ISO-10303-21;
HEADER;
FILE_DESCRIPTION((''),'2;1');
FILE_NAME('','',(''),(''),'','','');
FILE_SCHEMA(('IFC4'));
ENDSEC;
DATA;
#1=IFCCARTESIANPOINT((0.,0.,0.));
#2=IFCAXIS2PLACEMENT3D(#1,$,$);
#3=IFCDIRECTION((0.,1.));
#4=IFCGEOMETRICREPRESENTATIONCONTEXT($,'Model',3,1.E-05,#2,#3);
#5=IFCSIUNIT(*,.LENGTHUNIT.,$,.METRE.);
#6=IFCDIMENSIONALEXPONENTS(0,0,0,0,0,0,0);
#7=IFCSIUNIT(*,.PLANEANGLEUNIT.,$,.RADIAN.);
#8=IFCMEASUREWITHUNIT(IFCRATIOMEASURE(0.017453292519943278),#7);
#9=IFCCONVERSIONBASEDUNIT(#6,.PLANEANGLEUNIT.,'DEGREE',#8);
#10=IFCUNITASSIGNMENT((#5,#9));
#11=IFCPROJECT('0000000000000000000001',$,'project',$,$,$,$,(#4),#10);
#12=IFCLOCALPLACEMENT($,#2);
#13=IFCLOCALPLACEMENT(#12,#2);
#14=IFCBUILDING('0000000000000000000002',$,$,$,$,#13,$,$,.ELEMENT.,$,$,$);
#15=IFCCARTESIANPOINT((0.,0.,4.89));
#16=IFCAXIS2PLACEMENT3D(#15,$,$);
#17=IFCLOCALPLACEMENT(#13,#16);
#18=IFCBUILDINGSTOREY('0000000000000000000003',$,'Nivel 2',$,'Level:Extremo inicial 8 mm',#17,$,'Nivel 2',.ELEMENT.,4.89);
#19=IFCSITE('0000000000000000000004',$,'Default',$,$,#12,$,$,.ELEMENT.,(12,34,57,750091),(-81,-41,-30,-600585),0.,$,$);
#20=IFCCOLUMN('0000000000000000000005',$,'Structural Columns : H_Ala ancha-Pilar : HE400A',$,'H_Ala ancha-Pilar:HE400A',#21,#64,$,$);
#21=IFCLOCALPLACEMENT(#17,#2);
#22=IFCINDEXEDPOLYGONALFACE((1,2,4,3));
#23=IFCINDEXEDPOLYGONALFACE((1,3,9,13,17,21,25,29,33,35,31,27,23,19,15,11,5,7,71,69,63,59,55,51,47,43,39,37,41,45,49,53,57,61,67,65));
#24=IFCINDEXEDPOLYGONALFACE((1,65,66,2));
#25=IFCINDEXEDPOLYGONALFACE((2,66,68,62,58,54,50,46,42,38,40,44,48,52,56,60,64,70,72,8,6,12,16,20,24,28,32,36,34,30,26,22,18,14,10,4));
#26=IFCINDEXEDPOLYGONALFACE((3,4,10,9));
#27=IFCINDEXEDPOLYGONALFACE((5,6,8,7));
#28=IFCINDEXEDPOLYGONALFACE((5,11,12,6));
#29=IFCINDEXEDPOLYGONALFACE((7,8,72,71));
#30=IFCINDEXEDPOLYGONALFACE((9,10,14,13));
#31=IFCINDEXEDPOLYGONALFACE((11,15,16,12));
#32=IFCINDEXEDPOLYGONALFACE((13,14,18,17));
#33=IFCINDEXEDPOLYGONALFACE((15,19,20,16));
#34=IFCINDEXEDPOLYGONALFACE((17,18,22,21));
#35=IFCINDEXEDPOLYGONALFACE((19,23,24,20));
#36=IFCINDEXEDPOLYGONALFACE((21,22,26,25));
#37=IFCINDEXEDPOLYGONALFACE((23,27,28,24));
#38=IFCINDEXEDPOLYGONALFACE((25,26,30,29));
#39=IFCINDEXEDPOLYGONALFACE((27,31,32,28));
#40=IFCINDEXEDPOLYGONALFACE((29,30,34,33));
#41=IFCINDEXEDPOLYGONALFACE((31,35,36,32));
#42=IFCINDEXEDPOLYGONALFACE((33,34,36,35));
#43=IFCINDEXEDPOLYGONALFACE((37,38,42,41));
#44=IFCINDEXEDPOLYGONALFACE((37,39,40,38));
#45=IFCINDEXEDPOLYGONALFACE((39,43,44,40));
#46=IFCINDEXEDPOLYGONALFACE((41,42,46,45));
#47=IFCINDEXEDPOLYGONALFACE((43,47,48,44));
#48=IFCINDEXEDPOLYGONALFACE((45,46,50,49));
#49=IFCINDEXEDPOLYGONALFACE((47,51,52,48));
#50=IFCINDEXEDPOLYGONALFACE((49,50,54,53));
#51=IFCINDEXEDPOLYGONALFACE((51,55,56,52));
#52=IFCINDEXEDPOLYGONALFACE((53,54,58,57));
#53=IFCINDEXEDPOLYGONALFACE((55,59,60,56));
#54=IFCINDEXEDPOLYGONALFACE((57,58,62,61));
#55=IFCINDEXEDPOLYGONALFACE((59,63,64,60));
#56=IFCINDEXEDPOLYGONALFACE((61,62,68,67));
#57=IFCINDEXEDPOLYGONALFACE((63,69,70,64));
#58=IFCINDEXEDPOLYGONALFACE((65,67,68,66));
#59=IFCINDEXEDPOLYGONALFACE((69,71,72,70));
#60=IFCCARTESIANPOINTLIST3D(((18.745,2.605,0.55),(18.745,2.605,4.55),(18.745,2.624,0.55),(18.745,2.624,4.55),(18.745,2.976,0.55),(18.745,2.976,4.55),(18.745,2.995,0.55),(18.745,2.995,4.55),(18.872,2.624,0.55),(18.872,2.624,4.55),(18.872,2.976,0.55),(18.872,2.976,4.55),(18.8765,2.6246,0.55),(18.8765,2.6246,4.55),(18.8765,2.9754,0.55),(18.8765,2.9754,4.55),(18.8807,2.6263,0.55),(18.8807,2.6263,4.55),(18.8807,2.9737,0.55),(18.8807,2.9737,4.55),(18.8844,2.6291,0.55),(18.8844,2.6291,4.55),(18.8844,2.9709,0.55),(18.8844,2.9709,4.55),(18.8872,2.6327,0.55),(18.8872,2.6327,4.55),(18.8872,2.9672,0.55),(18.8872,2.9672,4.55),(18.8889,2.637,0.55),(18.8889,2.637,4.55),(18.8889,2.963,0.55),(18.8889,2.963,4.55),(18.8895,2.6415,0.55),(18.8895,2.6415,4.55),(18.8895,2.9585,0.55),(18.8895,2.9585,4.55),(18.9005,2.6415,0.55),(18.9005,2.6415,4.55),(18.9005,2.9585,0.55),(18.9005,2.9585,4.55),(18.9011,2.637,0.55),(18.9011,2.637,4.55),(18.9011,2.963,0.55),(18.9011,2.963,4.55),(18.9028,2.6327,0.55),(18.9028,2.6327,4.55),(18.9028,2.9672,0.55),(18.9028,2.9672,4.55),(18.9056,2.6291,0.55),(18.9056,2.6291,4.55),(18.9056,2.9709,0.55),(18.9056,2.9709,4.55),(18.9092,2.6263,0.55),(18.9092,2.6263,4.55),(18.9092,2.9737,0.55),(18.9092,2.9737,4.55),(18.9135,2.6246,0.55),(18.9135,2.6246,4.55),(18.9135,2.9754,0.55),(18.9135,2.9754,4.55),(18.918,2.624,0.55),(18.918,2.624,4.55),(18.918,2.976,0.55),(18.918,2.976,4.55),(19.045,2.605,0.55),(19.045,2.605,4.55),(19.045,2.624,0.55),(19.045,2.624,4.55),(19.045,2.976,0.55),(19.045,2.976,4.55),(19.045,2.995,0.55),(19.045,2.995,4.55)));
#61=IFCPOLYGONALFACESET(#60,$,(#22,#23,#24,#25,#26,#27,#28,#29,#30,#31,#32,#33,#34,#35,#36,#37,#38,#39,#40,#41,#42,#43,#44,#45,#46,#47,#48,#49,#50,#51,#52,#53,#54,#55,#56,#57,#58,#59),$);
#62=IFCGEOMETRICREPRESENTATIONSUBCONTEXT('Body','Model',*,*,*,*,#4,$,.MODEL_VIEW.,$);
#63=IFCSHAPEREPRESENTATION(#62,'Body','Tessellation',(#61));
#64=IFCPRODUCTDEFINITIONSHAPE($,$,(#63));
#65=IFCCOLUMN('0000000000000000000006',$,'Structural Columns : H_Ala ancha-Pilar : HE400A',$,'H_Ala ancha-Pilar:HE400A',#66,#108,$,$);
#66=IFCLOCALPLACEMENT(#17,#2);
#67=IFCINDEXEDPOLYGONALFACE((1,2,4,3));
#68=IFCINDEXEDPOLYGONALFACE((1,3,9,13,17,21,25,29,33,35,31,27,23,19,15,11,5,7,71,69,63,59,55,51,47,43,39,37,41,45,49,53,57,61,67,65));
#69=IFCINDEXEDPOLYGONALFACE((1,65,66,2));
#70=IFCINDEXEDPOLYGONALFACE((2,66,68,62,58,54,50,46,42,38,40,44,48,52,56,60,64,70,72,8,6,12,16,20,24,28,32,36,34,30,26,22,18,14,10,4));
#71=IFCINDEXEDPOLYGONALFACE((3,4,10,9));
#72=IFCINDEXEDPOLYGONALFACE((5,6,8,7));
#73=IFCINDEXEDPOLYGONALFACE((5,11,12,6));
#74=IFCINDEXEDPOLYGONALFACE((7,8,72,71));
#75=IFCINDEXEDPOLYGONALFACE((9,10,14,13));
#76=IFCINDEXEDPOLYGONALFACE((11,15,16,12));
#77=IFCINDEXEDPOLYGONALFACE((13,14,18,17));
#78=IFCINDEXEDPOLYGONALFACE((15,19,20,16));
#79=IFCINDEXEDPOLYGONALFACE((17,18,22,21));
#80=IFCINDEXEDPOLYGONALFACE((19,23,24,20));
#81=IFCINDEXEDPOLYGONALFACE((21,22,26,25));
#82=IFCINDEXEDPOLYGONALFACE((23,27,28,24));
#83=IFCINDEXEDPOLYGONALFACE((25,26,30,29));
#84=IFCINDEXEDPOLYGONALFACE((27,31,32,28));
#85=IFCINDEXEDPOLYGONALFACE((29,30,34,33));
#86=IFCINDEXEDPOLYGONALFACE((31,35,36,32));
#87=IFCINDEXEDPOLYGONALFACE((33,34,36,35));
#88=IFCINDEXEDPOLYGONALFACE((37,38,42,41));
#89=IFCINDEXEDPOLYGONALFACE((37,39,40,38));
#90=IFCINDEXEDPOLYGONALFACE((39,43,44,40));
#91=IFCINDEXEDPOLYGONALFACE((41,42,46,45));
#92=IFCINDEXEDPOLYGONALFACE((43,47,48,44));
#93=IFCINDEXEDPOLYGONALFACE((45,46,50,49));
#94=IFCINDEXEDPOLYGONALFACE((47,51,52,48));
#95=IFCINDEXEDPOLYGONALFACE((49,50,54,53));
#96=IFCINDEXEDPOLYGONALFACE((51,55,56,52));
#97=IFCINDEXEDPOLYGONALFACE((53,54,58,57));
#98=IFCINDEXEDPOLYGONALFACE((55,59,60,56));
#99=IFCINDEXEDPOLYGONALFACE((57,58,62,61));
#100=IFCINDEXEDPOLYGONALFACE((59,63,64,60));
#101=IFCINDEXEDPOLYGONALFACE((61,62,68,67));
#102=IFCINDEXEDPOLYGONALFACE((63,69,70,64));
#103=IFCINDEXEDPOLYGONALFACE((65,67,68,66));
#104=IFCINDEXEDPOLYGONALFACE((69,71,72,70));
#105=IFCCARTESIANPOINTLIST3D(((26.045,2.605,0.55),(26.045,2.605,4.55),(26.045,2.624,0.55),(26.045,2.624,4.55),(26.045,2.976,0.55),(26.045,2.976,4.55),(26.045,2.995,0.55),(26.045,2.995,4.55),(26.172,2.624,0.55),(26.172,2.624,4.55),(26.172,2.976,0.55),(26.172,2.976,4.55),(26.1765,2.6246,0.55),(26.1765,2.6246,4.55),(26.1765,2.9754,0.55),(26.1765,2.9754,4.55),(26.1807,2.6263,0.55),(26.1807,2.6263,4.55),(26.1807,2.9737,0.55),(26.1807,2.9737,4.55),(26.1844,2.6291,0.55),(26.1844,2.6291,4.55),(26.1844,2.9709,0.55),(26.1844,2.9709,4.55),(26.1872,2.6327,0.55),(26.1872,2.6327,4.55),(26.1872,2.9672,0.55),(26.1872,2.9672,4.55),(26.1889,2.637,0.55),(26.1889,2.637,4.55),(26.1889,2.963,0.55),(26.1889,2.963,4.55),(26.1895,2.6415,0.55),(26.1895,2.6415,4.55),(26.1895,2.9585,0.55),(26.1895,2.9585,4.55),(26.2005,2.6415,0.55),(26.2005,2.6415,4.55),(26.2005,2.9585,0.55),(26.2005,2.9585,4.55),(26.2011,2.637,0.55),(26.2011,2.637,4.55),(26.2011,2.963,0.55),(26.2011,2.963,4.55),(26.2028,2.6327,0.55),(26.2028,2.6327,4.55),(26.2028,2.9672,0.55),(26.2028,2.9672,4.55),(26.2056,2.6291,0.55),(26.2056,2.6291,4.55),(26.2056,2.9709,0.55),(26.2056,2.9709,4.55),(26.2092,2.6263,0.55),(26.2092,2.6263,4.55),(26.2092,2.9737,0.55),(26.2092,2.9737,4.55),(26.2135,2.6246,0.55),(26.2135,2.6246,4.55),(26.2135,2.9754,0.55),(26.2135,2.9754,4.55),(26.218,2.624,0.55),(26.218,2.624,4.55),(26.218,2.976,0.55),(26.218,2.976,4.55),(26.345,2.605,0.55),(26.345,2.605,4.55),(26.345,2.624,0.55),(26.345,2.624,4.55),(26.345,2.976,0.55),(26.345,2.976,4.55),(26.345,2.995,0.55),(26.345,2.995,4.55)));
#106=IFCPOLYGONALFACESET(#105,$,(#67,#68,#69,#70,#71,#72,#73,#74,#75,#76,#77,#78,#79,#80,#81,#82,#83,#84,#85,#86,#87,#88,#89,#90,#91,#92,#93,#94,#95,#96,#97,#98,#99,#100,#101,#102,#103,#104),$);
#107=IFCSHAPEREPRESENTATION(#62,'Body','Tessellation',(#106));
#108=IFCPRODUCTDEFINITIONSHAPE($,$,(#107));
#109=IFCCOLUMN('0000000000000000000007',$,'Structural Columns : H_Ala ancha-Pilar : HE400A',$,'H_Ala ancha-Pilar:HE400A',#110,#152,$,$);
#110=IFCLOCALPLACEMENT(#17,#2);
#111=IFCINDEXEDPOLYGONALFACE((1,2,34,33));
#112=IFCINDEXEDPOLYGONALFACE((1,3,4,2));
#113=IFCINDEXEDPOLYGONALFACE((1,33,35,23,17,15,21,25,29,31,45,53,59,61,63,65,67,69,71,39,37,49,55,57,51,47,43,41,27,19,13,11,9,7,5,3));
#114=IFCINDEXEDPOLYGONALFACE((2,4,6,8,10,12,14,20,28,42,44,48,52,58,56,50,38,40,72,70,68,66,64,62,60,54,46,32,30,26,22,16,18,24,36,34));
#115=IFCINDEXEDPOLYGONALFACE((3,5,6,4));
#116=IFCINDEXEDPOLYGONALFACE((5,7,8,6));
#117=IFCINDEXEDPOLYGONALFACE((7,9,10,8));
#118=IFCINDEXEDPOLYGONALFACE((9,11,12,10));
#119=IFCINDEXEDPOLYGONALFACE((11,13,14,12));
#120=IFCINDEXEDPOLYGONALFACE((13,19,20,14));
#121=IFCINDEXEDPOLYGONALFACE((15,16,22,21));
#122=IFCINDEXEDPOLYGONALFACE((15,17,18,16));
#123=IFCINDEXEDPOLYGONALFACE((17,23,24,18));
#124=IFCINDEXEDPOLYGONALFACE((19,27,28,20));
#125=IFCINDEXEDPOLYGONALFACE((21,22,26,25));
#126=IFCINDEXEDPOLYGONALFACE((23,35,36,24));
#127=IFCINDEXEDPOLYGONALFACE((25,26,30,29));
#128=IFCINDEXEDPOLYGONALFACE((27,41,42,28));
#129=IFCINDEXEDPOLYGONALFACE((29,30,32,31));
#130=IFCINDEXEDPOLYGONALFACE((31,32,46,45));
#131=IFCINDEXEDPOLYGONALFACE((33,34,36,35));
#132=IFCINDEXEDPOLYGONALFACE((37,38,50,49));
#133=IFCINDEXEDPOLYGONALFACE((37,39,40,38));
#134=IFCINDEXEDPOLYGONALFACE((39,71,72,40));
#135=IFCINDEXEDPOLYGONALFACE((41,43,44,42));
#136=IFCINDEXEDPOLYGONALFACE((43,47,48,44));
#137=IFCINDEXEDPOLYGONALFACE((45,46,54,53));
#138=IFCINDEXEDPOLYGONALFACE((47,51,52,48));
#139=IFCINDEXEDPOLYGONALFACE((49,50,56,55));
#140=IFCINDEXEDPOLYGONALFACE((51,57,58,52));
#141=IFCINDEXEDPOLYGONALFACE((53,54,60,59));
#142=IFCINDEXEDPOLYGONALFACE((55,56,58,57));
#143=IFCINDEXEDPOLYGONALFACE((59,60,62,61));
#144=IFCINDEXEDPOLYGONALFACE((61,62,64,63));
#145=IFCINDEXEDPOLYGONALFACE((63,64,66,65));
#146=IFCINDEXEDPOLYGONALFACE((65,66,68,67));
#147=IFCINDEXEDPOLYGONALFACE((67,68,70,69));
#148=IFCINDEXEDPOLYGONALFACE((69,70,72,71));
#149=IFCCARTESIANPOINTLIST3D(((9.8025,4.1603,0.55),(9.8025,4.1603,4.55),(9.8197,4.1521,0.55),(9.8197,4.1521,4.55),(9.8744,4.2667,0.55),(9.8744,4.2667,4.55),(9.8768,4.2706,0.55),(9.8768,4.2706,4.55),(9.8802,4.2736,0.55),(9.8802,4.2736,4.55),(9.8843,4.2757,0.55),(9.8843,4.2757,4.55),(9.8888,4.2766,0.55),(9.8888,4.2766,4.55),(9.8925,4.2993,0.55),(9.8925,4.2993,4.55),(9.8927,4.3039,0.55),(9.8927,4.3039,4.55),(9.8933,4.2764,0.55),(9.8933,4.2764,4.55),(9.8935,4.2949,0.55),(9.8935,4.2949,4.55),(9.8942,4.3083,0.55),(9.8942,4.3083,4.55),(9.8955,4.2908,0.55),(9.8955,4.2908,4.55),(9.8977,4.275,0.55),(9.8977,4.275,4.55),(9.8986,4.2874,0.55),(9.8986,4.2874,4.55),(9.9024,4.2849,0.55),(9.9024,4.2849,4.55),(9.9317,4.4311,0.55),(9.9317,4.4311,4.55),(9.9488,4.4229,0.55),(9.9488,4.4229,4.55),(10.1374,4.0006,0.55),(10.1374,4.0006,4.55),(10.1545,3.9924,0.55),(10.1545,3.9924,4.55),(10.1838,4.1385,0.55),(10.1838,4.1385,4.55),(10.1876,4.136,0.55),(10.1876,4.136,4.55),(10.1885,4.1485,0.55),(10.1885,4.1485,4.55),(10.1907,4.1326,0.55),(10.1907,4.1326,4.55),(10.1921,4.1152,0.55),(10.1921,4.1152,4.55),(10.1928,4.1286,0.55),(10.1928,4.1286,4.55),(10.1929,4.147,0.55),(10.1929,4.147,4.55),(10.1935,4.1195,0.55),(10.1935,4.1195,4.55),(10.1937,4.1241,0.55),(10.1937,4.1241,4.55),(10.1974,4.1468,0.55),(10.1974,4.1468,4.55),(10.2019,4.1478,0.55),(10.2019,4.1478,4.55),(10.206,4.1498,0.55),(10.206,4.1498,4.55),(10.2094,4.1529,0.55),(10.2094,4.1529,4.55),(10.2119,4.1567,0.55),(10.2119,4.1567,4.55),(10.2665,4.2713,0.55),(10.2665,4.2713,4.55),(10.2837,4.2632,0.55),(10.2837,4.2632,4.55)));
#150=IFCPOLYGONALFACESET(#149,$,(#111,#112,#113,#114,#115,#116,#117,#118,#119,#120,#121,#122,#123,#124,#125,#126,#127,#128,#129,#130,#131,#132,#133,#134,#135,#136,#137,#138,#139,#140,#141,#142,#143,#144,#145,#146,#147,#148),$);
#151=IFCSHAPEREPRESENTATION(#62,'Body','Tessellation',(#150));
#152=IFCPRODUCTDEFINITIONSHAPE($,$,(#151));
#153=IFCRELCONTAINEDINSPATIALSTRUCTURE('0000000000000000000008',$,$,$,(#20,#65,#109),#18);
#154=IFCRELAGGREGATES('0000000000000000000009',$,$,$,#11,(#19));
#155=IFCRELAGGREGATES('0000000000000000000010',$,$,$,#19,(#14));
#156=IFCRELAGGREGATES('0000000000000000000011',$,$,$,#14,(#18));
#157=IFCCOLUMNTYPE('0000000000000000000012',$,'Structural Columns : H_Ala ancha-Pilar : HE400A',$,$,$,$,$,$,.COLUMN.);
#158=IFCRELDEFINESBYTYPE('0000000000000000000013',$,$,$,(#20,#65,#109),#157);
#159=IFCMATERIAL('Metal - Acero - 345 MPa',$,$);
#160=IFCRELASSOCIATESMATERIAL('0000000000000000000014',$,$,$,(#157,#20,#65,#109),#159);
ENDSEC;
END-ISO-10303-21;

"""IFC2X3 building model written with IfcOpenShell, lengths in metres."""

from ifc_helpers import new_model, entity, si_unit, converted_unit, direction, frame, frame_2d, origin, place, context, subcontext, project, spatial, polyline, circle_curve, parameter, trimmed, segment, composite_curve, outline, extrude, source, transform, mapped, material, type_object, type_shapes, element, save


model = new_model("IFC2X3")

# Units and contexts
model_context = context("Model", 3, precision=1e-05, world=origin(), true_north=direction((0.0, 1.0)))
body_context = subcontext(model_context, "Body", "Model", "MODEL_VIEW")
ifc_project = project(units=[si_unit("LENGTHUNIT", "METRE"), converted_unit("PLANEANGLEUNIT", "DEGREE", entity("IfcRatioMeasure", 0.017453292519943278), si_unit("PLANEANGLEUNIT", "RADIAN"), dimensions=[0, 0, 0, 0, 0, 0, 0])], contexts=[model_context])

# Site, building, storey
site_placement = place(None, origin())
site = spatial("IfcSite", under=ifc_project, at=site_placement, Name="Default", CompositionType="ELEMENT", RefLatitude=(12, 34, 57, 750091), RefLongitude=(-81, -41, -30, -600585), RefElevation=0.0)
building_placement = place(site_placement, origin())
building = spatial("IfcBuilding", under=site, at=building_placement, CompositionType="ELEMENT")
storey_placement = place(building_placement, frame((0.0, 0.0, 4.89)))
storey = spatial("IfcBuildingStorey", under=building, at=storey_placement, Name="Nivel 2", ObjectType="Level:Extremo inicial 8 mm", LongName="Nivel 2", CompositionType="ELEMENT", Elevation=4.89)

# Columns
ifc_material_1 = material(Name="Metal - Acero - 345 MPa")
column_type_1 = type_object("IfcColumnType", Name="Structural Columns : H_Ala ancha-Pilar : HE400A", PredefinedType="COLUMN", material=ifc_material_1)
shared_shape_1 = source(origin(), body_context, "Body", "SweptSolid", [
    extrude(outline(composite_curve([segment(polyline([(0.176, -0.15), (0.195, -0.15)]), True, "CONTINUOUS"), segment(polyline([(0.195, -0.15), (0.195, 0.15)]), True, "CONTINUOUS"), segment(polyline([(0.195, 0.15), (0.176, 0.15)]), True, "CONTINUOUS"), segment(polyline([(0.176, 0.15), (0.176, 0.023)]), True, "CONTINUOUS"), segment(trimmed(circle_curve(frame_2d((0.1585, 0.023), x_axis=(1.0, 0.0)), 0.0175), [parameter(270.0)], [parameter(0.0)], True, "PARAMETER"), False, "CONTINUOUS"), segment(polyline([(0.1585, 0.0055), (-0.1585, 0.0055)]), True, "CONTINUOUS"), segment(trimmed(circle_curve(frame_2d((-0.1585, 0.023), x_axis=(0.0, -1.0)), 0.0175), [parameter(270.0)], [parameter(0.0)], True, "PARAMETER"), False, "CONTINUOUS"), segment(polyline([(-0.176, 0.023), (-0.176, 0.15)]), True, "CONTINUOUS"), segment(polyline([(-0.176, 0.15), (-0.195, 0.15)]), True, "CONTINUOUS"), segment(polyline([(-0.195, 0.15), (-0.195, -0.15)]), True, "CONTINUOUS"), segment(polyline([(-0.195, -0.15), (-0.176, -0.15)]), True, "CONTINUOUS"), segment(polyline([(-0.176, -0.15), (-0.176, -0.023)]), True, "CONTINUOUS"), segment(trimmed(circle_curve(frame_2d((-0.1585, -0.023), x_axis=(-1.0, 0.0)), 0.0175), [parameter(270.0)], [parameter(0.0)], True, "PARAMETER"), False, "CONTINUOUS"), segment(polyline([(-0.1585, -0.0055), (0.1585, -0.0055)]), True, "CONTINUOUS"), segment(trimmed(circle_curve(frame_2d((0.1585, -0.023), x_axis=(0.0, 1.0)), 0.0175), [parameter(270.0)], [parameter(0.0)], True, "PARAMETER"), False, "CONTINUOUS"), segment(polyline([(0.176, -0.023), (0.176, -0.15)]), True, "CONTINUOUS")], self_intersect=False)), frame((0.0, 0.0, 5.44), z_axis=(0.0, 0.0, 1.0), x_axis=(0.0, -1.0, 0.0)), (0.0, 0.0, 1.0), 4.0),
])
type_shapes(column_type_1, [shared_shape_1])
for number, where, name in (
    (1, (18.895, 2.8, -4.89), "Structural Columns : H_Ala ancha-Pilar : HE400A"),
    (2, (26.195, 2.8, -4.89), "Structural Columns : H_Ala ancha-Pilar : HE400A"),
):
    element("IfcColumn", number, at=place(storey_placement, frame(where)), inside=storey, type_object=column_type_1, material=ifc_material_1, Name=name, ObjectType="H_Ala ancha-Pilar:HE400A", context=body_context, shape_type="MappedRepresentation", body=[
        mapped(shared_shape_1, transform((0.0, 0.0, 0.0), scale=1.0)),
    ])
column_1_placement = place(storey_placement, frame((10.0431, 4.2117, -4.89), z_axis=(0.0, 0.0, 1.0), x_axis=(0.430511, 0.902585, 0.0)))
element("IfcColumn", 3, at=column_1_placement, inside=storey, type_object=column_type_1, material=ifc_material_1, Name="Structural Columns : H_Ala ancha-Pilar : HE400A", ObjectType="H_Ala ancha-Pilar:HE400A", context=body_context, shape_type="MappedRepresentation", body=[
    mapped(shared_shape_1, transform((0.0, 0.0, 0.0), scale=1.0)),
])

save(model, "model.ifc")
